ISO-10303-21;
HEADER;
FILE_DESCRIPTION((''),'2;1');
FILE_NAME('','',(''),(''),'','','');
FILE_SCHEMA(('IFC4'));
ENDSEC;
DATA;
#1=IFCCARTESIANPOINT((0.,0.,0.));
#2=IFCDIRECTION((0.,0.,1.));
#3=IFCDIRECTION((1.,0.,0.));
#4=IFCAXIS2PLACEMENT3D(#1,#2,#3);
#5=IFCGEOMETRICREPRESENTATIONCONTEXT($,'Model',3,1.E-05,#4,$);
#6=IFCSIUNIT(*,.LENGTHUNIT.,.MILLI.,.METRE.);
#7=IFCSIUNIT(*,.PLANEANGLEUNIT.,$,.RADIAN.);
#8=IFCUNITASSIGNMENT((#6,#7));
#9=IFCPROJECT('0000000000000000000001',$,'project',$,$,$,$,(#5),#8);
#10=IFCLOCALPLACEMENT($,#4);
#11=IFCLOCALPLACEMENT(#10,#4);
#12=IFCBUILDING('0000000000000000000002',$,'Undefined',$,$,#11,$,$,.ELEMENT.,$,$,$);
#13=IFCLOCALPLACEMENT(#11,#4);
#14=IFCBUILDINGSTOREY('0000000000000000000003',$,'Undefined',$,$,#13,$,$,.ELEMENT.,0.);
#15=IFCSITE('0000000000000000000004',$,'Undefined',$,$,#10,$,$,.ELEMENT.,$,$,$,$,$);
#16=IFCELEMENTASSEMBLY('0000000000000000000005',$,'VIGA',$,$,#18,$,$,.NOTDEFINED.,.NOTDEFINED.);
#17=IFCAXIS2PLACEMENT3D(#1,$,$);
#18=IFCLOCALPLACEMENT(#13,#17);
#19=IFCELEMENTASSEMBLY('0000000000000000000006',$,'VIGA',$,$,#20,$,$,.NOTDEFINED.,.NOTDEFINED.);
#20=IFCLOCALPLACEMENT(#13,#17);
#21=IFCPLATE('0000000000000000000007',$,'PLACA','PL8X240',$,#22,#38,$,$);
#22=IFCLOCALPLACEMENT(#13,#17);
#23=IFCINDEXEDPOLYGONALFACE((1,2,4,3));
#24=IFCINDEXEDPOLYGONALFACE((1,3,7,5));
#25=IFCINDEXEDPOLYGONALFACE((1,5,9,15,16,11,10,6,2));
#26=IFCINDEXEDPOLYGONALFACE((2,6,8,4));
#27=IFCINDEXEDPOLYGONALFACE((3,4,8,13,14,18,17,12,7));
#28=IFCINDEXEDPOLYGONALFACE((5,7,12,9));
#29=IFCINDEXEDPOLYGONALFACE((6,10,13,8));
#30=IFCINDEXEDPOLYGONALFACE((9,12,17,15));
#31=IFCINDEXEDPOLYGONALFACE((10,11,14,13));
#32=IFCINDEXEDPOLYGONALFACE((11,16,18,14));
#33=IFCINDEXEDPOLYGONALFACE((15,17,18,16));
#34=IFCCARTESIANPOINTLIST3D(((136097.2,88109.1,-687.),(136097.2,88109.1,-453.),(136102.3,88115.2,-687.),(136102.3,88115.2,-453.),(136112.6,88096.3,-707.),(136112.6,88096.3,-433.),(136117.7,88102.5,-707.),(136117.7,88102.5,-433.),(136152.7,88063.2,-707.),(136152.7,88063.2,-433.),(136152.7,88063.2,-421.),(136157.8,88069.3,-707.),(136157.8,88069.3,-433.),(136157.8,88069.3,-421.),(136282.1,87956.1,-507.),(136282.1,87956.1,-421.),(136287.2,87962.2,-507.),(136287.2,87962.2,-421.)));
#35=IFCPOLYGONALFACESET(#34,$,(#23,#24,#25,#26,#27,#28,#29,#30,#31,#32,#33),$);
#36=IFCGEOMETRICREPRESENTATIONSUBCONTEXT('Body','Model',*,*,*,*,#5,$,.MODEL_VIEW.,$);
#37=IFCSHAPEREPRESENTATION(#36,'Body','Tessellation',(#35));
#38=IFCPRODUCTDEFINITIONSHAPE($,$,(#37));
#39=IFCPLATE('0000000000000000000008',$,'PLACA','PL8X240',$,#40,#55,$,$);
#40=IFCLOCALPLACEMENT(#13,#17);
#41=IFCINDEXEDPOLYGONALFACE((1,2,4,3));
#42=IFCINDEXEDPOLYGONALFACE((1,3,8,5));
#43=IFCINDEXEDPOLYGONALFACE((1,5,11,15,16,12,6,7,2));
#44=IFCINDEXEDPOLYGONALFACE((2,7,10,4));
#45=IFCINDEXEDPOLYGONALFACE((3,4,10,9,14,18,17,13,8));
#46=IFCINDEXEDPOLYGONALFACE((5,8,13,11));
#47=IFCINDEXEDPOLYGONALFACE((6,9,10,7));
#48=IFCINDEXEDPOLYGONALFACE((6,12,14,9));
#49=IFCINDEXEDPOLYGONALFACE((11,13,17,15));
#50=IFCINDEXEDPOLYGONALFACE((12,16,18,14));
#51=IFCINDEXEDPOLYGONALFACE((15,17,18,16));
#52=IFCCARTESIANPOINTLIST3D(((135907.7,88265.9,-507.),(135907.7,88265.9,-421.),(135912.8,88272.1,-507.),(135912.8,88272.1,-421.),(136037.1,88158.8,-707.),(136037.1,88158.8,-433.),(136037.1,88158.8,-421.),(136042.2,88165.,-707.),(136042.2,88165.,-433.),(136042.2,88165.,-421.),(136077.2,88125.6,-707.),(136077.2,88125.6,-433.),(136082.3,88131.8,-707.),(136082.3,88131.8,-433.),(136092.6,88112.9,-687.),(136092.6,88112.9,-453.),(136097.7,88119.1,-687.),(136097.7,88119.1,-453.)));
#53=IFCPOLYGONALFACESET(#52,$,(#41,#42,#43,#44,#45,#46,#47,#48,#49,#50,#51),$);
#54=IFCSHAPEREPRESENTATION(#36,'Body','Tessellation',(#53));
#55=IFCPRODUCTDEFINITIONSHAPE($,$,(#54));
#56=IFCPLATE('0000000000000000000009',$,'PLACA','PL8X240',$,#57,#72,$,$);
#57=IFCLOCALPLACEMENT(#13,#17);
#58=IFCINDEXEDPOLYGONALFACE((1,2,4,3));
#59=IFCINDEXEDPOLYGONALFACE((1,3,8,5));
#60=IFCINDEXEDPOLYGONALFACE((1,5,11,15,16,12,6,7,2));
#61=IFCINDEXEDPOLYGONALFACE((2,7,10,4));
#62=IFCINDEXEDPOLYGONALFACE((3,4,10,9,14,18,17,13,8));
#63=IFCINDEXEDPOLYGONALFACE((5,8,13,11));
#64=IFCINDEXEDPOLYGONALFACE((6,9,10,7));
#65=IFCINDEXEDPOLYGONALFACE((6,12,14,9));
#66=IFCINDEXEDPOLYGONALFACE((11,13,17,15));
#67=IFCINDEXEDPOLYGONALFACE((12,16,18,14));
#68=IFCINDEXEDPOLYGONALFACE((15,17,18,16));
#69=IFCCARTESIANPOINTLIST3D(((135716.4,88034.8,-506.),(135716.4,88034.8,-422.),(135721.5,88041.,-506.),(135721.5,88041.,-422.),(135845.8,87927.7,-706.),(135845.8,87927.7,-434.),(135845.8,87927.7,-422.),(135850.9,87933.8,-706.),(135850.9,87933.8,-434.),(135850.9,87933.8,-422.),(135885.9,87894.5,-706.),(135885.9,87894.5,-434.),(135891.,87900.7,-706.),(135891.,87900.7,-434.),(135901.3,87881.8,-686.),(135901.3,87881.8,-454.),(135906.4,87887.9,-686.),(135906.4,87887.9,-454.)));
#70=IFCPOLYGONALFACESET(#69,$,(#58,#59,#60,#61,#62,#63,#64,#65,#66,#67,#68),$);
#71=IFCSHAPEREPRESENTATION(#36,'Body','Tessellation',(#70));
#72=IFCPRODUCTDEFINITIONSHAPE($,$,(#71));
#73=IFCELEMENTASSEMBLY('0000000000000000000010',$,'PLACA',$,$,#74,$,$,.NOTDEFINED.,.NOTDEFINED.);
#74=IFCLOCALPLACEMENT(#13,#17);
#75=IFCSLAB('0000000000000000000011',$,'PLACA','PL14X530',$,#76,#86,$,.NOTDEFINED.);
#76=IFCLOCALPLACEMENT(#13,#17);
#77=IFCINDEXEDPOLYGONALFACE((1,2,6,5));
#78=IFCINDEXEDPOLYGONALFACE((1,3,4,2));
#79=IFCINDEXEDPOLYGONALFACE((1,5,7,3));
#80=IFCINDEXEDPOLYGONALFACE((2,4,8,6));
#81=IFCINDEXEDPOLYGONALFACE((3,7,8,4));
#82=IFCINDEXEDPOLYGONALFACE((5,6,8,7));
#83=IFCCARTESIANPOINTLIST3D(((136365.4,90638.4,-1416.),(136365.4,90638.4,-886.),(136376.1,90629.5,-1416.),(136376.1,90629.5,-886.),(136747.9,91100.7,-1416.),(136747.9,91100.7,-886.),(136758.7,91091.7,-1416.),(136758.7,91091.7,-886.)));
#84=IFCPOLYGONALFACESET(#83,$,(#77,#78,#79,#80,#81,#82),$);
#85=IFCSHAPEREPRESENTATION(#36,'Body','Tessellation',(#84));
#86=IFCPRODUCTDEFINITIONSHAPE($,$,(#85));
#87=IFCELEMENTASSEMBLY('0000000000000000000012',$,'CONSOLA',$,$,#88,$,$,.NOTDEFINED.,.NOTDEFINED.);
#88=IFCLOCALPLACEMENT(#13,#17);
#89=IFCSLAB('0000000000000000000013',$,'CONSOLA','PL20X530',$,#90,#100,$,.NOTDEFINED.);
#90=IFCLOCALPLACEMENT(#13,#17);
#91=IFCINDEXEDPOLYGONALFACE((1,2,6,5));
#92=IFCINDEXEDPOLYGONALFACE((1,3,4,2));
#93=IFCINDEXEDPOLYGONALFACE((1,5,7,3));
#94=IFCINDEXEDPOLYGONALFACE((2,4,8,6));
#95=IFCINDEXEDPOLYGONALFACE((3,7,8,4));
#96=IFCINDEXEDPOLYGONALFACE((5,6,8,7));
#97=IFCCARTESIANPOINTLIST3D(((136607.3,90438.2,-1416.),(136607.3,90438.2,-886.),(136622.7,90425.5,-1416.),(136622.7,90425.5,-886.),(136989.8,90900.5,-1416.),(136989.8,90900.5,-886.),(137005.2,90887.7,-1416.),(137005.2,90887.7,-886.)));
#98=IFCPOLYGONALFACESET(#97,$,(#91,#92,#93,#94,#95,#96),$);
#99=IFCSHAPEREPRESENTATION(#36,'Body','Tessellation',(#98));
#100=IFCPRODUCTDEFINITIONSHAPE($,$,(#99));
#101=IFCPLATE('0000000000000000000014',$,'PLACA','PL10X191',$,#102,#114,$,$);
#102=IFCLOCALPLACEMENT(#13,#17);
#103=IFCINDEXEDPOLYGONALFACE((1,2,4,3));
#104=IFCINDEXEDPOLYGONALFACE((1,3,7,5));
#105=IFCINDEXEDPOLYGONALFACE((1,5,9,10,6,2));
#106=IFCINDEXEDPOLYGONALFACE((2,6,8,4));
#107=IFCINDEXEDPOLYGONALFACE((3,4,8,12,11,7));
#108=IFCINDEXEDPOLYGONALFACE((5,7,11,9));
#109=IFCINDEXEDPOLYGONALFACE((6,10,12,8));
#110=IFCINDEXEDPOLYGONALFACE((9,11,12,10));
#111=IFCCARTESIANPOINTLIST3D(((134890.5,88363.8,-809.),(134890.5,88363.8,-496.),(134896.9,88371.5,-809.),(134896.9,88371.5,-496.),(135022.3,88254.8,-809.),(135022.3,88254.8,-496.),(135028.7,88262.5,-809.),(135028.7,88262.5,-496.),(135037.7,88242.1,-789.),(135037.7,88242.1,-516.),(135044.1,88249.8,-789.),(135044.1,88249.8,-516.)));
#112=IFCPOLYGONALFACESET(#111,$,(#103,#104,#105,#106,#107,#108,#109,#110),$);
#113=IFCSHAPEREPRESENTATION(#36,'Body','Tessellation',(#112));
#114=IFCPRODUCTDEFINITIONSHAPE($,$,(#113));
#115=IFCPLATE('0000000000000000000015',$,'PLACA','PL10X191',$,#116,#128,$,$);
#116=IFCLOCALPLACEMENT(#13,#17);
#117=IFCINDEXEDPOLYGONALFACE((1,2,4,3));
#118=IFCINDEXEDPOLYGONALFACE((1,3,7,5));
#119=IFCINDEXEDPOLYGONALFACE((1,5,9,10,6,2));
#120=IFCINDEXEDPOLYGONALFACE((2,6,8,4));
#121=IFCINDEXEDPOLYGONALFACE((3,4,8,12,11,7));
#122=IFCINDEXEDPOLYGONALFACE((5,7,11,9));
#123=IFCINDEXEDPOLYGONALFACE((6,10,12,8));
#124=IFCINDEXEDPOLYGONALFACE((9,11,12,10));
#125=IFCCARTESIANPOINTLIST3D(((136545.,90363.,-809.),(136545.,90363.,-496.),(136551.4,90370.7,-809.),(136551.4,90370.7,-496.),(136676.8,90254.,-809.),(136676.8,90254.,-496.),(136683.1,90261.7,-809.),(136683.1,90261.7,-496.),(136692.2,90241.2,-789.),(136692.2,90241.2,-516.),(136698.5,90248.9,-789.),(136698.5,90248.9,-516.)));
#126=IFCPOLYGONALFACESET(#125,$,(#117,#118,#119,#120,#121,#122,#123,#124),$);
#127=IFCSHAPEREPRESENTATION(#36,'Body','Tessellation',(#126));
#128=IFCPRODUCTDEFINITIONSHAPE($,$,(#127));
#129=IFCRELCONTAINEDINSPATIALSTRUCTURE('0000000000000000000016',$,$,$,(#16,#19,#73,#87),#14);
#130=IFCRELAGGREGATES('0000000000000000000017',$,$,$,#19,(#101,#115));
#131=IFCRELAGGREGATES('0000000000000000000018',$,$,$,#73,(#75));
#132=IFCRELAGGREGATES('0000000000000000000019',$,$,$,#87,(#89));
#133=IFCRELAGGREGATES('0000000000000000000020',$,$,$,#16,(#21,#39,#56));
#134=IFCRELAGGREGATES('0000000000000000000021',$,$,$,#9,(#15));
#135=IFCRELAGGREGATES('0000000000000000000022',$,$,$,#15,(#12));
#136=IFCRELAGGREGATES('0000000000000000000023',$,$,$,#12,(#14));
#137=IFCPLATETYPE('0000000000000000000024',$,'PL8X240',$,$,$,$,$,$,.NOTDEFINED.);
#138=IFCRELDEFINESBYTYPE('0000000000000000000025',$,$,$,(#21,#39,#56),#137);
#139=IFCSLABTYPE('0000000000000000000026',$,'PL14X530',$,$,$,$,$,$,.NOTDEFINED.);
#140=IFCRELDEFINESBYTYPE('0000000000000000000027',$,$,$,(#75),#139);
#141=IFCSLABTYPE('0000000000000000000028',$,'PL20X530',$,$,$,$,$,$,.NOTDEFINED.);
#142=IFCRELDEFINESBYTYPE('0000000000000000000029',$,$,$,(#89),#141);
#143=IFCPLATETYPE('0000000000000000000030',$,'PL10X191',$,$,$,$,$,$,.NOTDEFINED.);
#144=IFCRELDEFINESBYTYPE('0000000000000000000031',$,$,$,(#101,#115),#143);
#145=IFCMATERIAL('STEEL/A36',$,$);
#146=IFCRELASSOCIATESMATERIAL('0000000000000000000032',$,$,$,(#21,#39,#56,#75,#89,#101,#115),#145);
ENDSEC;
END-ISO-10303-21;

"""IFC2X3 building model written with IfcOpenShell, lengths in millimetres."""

from ifc_helpers import new_model, si_unit, frame, origin_with_axes, place, context, subcontext, project, spatial, polyline, outline, extrude, material, type_object, element, aggregate, save


model = new_model("IFC2X3")

# Units and contexts
model_context = context("Model", 3, precision=1e-05, world=origin_with_axes())
body_context = subcontext(model_context, "Body", "Model", "MODEL_VIEW")
ifc_project = project(units=[si_unit("LENGTHUNIT", "METRE", prefix="MILLI"), si_unit("PLANEANGLEUNIT", "RADIAN")], contexts=[model_context])

# Site, building, storey
site_placement = place(None, origin_with_axes())
site = spatial("IfcSite", under=ifc_project, at=site_placement, Name="Undefined", CompositionType="ELEMENT")
building_placement = place(site_placement, origin_with_axes())
building = spatial("IfcBuilding", under=site, at=building_placement, Name="Undefined", CompositionType="ELEMENT")
storey_placement = place(building_placement, origin_with_axes())
storey = spatial("IfcBuildingStorey", under=building, at=storey_placement, Name="Undefined", CompositionType="ELEMENT", Elevation=0.0)

# Element assembly
assembly_1_placement = place(storey_placement, origin_with_axes())
assembly_1 = element("IfcElementAssembly", 1, at=assembly_1_placement, inside=storey, Name="VIGA", AssemblyPlace="NOTDEFINED", PredefinedType="NOTDEFINED")
ifc_material_1 = material(Name="STEEL/A36")

# Element assembly
assembly_2_placement = place(storey_placement, origin_with_axes())
assembly_2 = element("IfcElementAssembly", 2, at=assembly_2_placement, inside=storey, Name="VIGA", AssemblyPlace="NOTDEFINED", PredefinedType="NOTDEFINED")

# Plates
plate_type_1 = type_object("IfcPlateType", Name="PL8X240", PredefinedType="NOTDEFINED")
plate_1_placement = place(assembly_1_placement, frame((136284.7, 87959.1, -707.0), z_axis=(0.63756, 0.770401, 0.0), x_axis=(-0.770401, 0.63756, 0.0)))
plate_1 = element("IfcPlate", 3, at=plate_1_placement, type_object=plate_type_1, material=ifc_material_1, Name="PLACA", Description="PL8X240", context=body_context, shape_type="SweptSolid", body=[
    extrude(outline(polyline([(0.0, 200.0), (168.0, 0.0), (220.0, 0.0), (240.0, 20.0), (240.0, 254.0), (220.0, 274.0), (168.0, 274.0), (168.0, 286.0), (0.0, 286.0), (0.0, 200.0)])), frame((0.0, 0.0, -4.0), z_axis=(0.0, 0.0, 1.0), x_axis=(1.0, 0.0, 0.0)), (0.0, 0.0, 1.0), 8.0),
])
plate_2_placement = place(assembly_1_placement, frame((136095.1, 88116.0, -707.0), z_axis=(0.63756, 0.770401, 0.0), x_axis=(-0.770401, 0.63756, 0.0)))
plate_2 = element("IfcPlate", 4, at=plate_2_placement, type_object=plate_type_1, material=ifc_material_1, Name="PLACA", Description="PL8X240", context=body_context, shape_type="SweptSolid", body=[
    extrude(outline(polyline([(0.0, 20.0), (20.0, 0.0), (72.0, 0.0), (240.0, 200.0), (240.0, 286.0), (72.0, 286.0), (72.0, 274.0), (20.0, 274.0), (0.0, 254.0), (0.0, 20.0)])), frame((0.0, 0.0, -4.0), z_axis=(0.0, 0.0, 1.0), x_axis=(1.0, 0.0, 0.0)), (0.0, 0.0, 1.0), 8.0),
])
plate_3_placement = place(assembly_1_placement, frame((135903.9, 87884.9, -706.0), z_axis=(0.63756, 0.770401, 0.0), x_axis=(-0.770401, 0.63756, 0.0)))
plate_3 = element("IfcPlate", 5, at=plate_3_placement, type_object=plate_type_1, material=ifc_material_1, Name="PLACA", Description="PL8X240", context=body_context, shape_type="SweptSolid", body=[
    extrude(outline(polyline([(0.0, 20.0), (20.0, 0.0), (72.0, 0.0), (240.0, 200.0), (240.0, 284.0), (72.0, 284.0), (72.0, 272.0), (20.0, 272.0), (0.0, 252.0), (0.0, 20.0)])), frame((0.0, 0.0, -4.0), z_axis=(0.0, 0.0, 1.0), x_axis=(1.0, 0.0, 0.0)), (0.0, 0.0, 1.0), 8.0),
])

# Element assemblies, slabs
assembly_3_placement = place(storey_placement, origin_with_axes())
assembly_3 = element("IfcElementAssembly", 6, at=assembly_3_placement, inside=storey, Name="PLACA", AssemblyPlace="NOTDEFINED", PredefinedType="NOTDEFINED")
slab_type_1 = type_object("IfcSlabType", Name="PL14X530", PredefinedType="NOTDEFINED")
slab_1_placement = place(assembly_3_placement, frame((136370.8, 90634.0, -886.0), z_axis=(-0.770401, 0.63756, 0.0), x_axis=(0.63756, 0.770401, -0.000002)))
slab_1 = element("IfcSlab", 7, at=slab_1_placement, type_object=slab_type_1, material=ifc_material_1, Name="PLACA", Description="PL14X530", PredefinedType="NOTDEFINED", context=body_context, shape_type="SweptSolid", body=[
    extrude(outline(polyline([(0.0, 0.0), (600.0, 0.0), (600.0, 530.0), (0.0, 530.0), (0.0, 0.0)])), frame((0.0, 0.0, -7.0), z_axis=(0.0, 0.0, 1.0), x_axis=(1.0, 0.0, 0.0)), (0.0, 0.0, 1.0), 14.0),
])
assembly_4_placement = place(storey_placement, origin_with_axes())
assembly_4 = element("IfcElementAssembly", 8, at=assembly_4_placement, inside=storey, Name="CONSOLA", AssemblyPlace="NOTDEFINED", PredefinedType="NOTDEFINED")
slab_type_2 = type_object("IfcSlabType", Name="PL20X530", PredefinedType="NOTDEFINED")
slab_2_placement = place(assembly_4_placement, frame((136615.0, 90431.9, -886.0), z_axis=(-0.770401, 0.63756, 0.0), x_axis=(0.63756, 0.770401, -0.000002)))
slab_2 = element("IfcSlab", 9, at=slab_2_placement, type_object=slab_type_2, material=ifc_material_1, Name="CONSOLA", Description="PL20X530", PredefinedType="NOTDEFINED", context=body_context, shape_type="SweptSolid", body=[
    extrude(outline(polyline([(0.0, 0.0), (600.0, 0.0), (600.0, 530.0), (0.0, 530.0), (0.0, 0.0)])), frame((0.0, 0.0, -10.0), z_axis=(0.0, 0.0, 1.0), x_axis=(1.0, 0.0, 0.0)), (0.0, 0.0, 1.0), 20.0),
])

# Plates
plate_type_2 = type_object("IfcPlateType", Name="PL10X191", PredefinedType="NOTDEFINED")
plate_4_placement = place(assembly_2_placement, frame((135040.9, 88245.9, -809.0), z_axis=(0.637562, 0.770399, 0.0), x_axis=(-0.770399, 0.637562, 0.0)))
plate_4 = element("IfcPlate", 10, at=plate_4_placement, type_object=plate_type_2, material=ifc_material_1, Name="PLACA", Description="PL10X191", context=body_context, shape_type="SweptSolid", body=[
    extrude(outline(polyline([(0.0, 20.0), (20.0, 0.0), (191.0, 0.0), (191.0, 313.0), (20.0, 313.0), (0.0, 293.0), (0.0, 20.0)])), frame((0.0, 0.0, -5.0), z_axis=(0.0, 0.0, 1.0), x_axis=(1.0, 0.0, 0.0)), (0.0, 0.0, 1.0), 10.0),
])
plate_5_placement = place(assembly_2_placement, frame((136695.4, 90245.1, -809.0), z_axis=(0.637562, 0.770399, 0.0), x_axis=(-0.770399, 0.637562, 0.0)))
plate_5 = element("IfcPlate", 11, at=plate_5_placement, type_object=plate_type_2, material=ifc_material_1, Name="PLACA", Description="PL10X191", context=body_context, shape_type="SweptSolid", body=[
    extrude(outline(polyline([(0.0, 20.0), (20.0, 0.0), (191.0, 0.0), (191.0, 313.0), (20.0, 313.0), (0.0, 293.0), (0.0, 20.0)])), frame((0.0, 0.0, -5.0), z_axis=(0.0, 0.0, 1.0), x_axis=(1.0, 0.0, 0.0)), (0.0, 0.0, 1.0), 10.0),
])
aggregate(assembly_2, [plate_4, plate_5])

aggregate(assembly_3, [slab_1])
aggregate(assembly_4, [slab_2])
aggregate(assembly_1, [plate_1, plate_2, plate_3])

save(model, "model.ifc")
